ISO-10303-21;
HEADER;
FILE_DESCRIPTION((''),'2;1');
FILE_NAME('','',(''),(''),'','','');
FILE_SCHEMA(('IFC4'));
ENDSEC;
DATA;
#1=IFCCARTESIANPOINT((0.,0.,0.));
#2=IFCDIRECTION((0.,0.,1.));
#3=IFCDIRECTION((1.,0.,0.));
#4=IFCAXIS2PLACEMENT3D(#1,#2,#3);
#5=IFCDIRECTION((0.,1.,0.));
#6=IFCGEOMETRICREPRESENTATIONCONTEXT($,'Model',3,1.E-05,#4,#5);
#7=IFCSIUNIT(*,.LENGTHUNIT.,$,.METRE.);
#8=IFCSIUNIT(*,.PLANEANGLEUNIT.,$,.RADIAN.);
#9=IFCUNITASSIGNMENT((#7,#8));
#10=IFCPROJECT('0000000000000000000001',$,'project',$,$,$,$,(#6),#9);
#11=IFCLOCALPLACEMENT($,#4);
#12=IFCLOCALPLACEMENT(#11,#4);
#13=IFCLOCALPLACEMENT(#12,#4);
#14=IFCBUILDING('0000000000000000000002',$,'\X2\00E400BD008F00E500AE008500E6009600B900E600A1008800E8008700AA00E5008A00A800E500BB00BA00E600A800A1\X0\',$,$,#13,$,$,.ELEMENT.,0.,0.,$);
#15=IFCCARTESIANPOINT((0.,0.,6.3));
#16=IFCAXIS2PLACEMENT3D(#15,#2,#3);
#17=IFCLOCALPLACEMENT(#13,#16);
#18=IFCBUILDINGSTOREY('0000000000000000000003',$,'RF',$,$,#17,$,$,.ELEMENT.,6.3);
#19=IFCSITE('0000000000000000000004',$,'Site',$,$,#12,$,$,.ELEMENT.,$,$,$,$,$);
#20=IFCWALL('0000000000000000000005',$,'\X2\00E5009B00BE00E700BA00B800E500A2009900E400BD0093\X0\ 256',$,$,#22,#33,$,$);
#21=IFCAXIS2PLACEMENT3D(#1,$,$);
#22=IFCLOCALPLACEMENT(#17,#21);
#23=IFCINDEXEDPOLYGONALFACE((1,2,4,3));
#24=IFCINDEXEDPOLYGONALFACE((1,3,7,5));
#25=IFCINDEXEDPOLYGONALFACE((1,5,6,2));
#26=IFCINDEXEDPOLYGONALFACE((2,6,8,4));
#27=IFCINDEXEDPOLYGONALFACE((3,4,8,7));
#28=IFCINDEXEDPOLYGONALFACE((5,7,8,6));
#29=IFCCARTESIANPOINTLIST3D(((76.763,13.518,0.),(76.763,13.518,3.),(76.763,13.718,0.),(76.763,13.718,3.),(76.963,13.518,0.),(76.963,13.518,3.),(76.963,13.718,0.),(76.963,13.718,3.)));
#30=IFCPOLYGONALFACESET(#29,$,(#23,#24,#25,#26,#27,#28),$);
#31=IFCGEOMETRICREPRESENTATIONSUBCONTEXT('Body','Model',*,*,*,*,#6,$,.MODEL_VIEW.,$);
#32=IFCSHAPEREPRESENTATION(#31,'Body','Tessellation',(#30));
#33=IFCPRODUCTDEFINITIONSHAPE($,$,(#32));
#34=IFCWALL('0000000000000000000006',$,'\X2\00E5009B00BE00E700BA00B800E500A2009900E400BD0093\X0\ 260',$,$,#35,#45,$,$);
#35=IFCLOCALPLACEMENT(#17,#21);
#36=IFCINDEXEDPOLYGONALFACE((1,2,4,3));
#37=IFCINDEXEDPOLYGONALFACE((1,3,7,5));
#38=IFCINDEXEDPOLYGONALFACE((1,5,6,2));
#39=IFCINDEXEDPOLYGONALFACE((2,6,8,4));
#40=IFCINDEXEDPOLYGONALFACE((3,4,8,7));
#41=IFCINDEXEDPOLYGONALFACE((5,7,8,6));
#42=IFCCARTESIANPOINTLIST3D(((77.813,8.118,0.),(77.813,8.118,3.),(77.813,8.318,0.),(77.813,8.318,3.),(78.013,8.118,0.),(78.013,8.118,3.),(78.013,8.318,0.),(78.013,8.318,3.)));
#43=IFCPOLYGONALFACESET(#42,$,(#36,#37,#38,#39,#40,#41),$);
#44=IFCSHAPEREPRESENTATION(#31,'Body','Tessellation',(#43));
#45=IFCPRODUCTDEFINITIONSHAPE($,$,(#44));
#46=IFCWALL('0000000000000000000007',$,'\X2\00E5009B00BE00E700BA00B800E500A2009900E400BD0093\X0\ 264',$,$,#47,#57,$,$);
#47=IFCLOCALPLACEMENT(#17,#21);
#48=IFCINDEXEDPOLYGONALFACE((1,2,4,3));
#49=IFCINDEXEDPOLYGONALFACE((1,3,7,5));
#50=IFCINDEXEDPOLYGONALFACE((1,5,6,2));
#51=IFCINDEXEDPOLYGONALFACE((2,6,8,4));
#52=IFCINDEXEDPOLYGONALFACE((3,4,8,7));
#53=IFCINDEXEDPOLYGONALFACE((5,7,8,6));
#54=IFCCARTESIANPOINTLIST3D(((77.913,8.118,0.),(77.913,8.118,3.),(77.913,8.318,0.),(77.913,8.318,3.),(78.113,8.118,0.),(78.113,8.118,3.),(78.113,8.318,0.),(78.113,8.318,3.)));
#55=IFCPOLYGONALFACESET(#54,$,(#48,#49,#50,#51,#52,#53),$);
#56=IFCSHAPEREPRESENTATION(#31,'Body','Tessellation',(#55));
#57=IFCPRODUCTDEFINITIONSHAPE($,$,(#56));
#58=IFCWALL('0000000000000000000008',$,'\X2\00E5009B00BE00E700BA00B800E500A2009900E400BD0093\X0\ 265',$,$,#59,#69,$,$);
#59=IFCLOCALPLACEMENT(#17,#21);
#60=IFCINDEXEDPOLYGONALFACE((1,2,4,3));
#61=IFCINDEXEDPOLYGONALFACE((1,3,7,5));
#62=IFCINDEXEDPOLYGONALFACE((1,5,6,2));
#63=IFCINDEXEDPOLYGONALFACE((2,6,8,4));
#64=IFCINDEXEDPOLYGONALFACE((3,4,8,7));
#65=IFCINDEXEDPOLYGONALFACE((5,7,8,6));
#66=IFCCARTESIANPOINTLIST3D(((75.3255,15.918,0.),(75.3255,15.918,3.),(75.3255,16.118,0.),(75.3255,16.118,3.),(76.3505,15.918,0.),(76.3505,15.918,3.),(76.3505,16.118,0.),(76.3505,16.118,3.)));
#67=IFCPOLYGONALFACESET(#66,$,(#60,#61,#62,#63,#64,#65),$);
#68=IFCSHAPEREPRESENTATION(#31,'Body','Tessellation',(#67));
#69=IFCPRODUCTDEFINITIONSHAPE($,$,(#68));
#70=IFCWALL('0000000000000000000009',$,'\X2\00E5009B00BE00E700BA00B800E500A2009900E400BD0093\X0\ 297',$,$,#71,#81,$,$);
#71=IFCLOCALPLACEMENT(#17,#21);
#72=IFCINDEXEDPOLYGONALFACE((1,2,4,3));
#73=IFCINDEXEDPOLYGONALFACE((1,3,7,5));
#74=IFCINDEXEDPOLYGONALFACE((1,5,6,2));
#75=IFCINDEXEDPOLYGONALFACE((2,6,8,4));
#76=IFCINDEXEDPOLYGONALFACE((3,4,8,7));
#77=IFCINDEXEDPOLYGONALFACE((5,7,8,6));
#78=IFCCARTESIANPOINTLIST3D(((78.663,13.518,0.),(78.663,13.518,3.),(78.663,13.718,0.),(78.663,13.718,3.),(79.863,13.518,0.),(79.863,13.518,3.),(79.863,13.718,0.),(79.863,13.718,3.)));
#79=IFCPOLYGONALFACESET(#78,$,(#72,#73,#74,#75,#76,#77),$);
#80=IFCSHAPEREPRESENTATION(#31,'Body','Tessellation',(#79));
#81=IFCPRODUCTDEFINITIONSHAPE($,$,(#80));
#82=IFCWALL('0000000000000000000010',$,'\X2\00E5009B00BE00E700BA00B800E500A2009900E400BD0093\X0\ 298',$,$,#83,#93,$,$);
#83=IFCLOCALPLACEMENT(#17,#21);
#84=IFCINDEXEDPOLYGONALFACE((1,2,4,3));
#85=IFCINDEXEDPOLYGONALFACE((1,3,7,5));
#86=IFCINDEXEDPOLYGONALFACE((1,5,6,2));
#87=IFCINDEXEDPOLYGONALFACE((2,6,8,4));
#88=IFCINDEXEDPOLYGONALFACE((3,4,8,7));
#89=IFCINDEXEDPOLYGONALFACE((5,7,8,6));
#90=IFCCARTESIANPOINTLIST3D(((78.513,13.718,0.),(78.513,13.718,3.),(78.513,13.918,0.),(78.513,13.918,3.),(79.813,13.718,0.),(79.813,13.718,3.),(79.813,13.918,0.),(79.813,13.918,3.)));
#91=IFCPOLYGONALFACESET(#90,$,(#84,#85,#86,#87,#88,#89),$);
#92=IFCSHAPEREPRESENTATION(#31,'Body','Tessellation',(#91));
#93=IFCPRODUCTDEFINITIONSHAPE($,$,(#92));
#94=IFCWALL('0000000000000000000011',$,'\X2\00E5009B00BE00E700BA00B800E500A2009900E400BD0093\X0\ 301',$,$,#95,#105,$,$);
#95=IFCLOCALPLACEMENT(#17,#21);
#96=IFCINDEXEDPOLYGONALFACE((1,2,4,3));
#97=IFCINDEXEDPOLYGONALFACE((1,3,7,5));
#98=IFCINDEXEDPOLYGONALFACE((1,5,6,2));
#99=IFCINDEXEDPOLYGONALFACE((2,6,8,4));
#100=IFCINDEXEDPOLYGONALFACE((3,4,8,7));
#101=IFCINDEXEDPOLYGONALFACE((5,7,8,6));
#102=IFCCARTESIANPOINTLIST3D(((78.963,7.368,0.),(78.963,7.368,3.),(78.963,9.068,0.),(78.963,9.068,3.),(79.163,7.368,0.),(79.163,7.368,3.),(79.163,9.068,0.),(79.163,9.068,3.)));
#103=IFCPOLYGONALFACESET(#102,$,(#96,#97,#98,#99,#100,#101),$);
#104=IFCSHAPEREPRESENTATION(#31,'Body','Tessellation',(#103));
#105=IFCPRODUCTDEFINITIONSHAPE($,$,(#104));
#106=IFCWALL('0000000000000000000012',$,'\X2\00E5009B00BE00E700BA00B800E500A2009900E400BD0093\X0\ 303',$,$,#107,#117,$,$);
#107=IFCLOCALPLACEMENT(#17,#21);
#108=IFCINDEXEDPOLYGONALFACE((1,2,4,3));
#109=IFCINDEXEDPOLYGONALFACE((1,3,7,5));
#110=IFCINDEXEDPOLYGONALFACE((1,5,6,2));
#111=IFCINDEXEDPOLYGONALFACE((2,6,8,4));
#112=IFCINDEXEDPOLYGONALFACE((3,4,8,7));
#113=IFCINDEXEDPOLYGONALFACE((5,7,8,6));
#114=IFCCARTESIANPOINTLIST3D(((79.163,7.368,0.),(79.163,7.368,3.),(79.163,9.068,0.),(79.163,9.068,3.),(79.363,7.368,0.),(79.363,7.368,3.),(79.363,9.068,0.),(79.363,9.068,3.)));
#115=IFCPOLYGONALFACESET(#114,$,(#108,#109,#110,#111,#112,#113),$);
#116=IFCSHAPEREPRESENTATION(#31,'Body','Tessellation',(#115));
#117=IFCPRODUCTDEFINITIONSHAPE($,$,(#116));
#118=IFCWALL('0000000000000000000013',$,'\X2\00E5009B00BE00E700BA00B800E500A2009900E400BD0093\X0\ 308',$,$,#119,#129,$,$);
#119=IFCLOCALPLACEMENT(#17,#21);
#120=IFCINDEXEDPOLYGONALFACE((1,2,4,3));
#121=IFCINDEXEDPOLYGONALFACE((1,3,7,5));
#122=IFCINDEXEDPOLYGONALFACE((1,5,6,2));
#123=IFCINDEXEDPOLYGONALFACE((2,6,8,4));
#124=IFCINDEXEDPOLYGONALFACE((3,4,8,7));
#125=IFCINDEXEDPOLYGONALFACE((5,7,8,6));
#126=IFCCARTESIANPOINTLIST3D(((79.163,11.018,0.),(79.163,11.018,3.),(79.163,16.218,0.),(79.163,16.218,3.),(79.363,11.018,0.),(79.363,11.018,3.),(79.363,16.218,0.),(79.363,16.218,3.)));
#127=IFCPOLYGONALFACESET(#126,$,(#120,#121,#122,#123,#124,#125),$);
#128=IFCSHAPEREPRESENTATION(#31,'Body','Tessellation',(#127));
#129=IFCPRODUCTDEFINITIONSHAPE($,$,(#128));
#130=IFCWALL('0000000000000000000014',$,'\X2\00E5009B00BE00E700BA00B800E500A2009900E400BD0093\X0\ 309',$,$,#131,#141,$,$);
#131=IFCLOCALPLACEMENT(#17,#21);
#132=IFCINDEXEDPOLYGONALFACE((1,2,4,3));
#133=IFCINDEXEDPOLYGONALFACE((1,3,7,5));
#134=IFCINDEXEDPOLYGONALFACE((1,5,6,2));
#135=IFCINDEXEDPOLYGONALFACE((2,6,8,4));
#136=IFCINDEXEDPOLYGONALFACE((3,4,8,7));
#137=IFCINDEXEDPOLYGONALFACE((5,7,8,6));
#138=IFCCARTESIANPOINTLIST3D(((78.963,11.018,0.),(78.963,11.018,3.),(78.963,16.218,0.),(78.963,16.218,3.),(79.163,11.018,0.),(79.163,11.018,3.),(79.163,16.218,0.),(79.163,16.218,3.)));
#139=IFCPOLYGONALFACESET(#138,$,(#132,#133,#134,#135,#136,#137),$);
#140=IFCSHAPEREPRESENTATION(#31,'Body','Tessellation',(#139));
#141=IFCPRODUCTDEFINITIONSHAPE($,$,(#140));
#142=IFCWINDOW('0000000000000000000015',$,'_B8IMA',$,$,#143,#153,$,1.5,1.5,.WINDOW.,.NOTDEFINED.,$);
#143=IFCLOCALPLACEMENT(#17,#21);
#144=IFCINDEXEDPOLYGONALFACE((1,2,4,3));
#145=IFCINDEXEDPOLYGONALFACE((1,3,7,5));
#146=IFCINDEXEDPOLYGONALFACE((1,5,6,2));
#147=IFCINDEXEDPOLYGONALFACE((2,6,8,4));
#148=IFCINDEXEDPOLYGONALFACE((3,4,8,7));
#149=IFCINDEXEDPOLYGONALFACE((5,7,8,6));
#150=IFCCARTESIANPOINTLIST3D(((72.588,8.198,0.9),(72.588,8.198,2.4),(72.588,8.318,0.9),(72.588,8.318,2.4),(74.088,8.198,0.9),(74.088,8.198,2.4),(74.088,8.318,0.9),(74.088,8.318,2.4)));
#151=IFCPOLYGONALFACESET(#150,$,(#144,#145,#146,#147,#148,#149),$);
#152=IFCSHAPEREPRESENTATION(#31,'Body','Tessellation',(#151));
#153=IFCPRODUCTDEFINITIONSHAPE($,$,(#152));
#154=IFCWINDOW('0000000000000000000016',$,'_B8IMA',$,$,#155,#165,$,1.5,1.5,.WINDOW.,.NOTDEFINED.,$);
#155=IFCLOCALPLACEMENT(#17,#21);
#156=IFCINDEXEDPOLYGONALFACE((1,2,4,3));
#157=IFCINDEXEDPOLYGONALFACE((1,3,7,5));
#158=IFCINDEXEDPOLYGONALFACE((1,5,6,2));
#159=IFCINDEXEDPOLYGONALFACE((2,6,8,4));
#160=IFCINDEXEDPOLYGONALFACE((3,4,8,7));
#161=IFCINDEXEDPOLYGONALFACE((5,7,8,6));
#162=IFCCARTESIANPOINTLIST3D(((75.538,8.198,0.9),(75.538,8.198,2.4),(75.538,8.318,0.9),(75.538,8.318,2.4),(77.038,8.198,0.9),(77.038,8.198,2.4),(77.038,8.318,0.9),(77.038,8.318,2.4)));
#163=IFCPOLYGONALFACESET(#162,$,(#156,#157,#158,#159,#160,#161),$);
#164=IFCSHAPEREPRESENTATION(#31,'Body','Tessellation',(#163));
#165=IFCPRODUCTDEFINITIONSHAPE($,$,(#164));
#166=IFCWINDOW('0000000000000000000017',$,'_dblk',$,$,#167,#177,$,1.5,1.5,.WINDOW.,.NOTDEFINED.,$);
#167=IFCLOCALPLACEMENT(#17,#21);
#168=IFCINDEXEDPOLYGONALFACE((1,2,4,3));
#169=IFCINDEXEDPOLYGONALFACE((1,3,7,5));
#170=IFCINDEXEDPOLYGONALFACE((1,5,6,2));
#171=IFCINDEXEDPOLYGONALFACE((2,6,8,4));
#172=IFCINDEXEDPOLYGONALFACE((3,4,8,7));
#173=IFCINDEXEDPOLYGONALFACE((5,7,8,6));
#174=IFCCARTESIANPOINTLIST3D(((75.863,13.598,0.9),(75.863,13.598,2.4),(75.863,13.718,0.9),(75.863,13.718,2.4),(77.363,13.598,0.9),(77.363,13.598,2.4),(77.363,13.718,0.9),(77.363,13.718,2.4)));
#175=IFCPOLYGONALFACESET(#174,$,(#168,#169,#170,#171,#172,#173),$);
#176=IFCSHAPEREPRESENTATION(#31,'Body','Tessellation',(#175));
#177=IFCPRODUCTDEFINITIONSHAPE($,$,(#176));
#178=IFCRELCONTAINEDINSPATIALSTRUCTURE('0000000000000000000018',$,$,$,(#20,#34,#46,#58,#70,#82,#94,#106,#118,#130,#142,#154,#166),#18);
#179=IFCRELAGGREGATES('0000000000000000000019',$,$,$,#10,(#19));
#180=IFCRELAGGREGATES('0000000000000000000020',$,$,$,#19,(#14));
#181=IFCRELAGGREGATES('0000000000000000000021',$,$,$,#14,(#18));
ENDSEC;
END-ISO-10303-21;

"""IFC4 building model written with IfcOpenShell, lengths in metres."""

from ifc_helpers import new_model, si_unit, direction, frame, frame_2d, origin_with_axes, place, context, subcontext, project, spatial, rectangle, extrude, element, save


model = new_model("IFC4")

# Units and contexts
model_context = context("Model", 3, precision=1e-05, world=origin_with_axes(), true_north=direction((0.0, 1.0, 0.0)))
body_context = subcontext(model_context, "Body", "Model", "MODEL_VIEW")
ifc_project = project(units=[si_unit("LENGTHUNIT", "METRE"), si_unit("PLANEANGLEUNIT", "RADIAN")], contexts=[model_context])

# Site, building, storey
placement = place(None, origin_with_axes())
site_placement = place(placement, origin_with_axes())
site = spatial("IfcSite", under=ifc_project, at=site_placement, Name="Site", CompositionType="ELEMENT")
building_placement = place(site_placement, origin_with_axes())
building = spatial("IfcBuilding", under=site, at=building_placement, Name="ä½\u008få®\u0085æ\u0096¹æ¡\u0088è\u0087ªå\u008a¨å»ºæ¨¡", CompositionType="ELEMENT", ElevationOfRefHeight=0.0, ElevationOfTerrain=0.0)
storey_placement = place(building_placement, frame((0.0, 0.0, 6.3), z_axis=(0.0, 0.0, 1.0), x_axis=(1.0, 0.0, 0.0)))
storey = spatial("IfcBuildingStorey", under=building, at=storey_placement, Name="RF", CompositionType="ELEMENT", Elevation=6.3)

# Walls
for number, where, z_axis, x_axis, name in (
    (1, (76.863, 13.618, 0.0), (0.0, 0.0, 1.0), (0.0, 1.0, 0.0), "å\u009b¾çº¸å¢\u0099ä½\u0093 256"),
    (2, (77.913, 8.218, 0.0), (0.0, 0.0, 1.0), (0.0, 1.0, 0.0), "å\u009b¾çº¸å¢\u0099ä½\u0093 260"),
    (3, (78.013, 8.218, 0.0), (0.0, 0.0, 1.0), (0.0, -1.0, 0.0), "å\u009b¾çº¸å¢\u0099ä½\u0093 264"),
):
    element("IfcWall", number, at=place(storey_placement, frame(where, z_axis=z_axis, x_axis=x_axis)), inside=storey, Name=name, context=body_context, shape_type="SweptSolid", body=[
        extrude(rectangle(XDim=0.2, YDim=0.2, at=frame_2d((0.0, 0.0), x_axis=(1.0, 0.0, 0.0))), frame((0.0, 0.0, 0.0), z_axis=(0.0, 0.0, 1.0)), (0.0, 0.0, 1.0), 3.0),
    ])
wall_1_placement = place(storey_placement, frame((75.838, 16.018, 0.0), z_axis=(0.0, 0.0, 1.0), x_axis=(1.0, 0.0, 0.0)))
element("IfcWall", 4, at=wall_1_placement, inside=storey, Name="å\u009b¾çº¸å¢\u0099ä½\u0093 265", context=body_context, shape_type="SweptSolid", body=[
    extrude(rectangle(XDim=1.025, YDim=0.2, at=frame_2d((0.0, 0.0), x_axis=(1.0, 0.0, 0.0))), frame((0.0, 0.0, 0.0), z_axis=(0.0, 0.0, 1.0)), (0.0, 0.0, 1.0), 3.0),
])
wall_2_placement = place(storey_placement, frame((79.263, 13.618, 0.0), z_axis=(0.0, 0.0, 1.0), x_axis=(1.0, 0.0, 0.0)))
element("IfcWall", 5, at=wall_2_placement, inside=storey, Name="å\u009b¾çº¸å¢\u0099ä½\u0093 297", context=body_context, shape_type="SweptSolid", body=[
    extrude(rectangle(XDim=1.2, YDim=0.2, at=frame_2d((0.0, 0.0), x_axis=(1.0, 0.0, 0.0))), frame((0.0, 0.0, 0.0), z_axis=(0.0, 0.0, 1.0)), (0.0, 0.0, 1.0), 3.0),
])
wall_3_placement = place(storey_placement, frame((79.163, 13.818, 0.0), z_axis=(0.0, 0.0, 1.0), x_axis=(1.0, 0.0, 0.0)))
element("IfcWall", 6, at=wall_3_placement, inside=storey, Name="å\u009b¾çº¸å¢\u0099ä½\u0093 298", context=body_context, shape_type="SweptSolid", body=[
    extrude(rectangle(XDim=1.3, YDim=0.2, at=frame_2d((0.0, 0.0), x_axis=(1.0, 0.0, 0.0))), frame((0.0, 0.0, 0.0), z_axis=(0.0, 0.0, 1.0)), (0.0, 0.0, 1.0), 3.0),
])
for number, where, z_axis, x_axis, name in (
    (7, (79.063, 8.218, 0.0), (0.0, 0.0, 1.0), (0.0, -1.0, 0.0), "å\u009b¾çº¸å¢\u0099ä½\u0093 301"),
    (8, (79.263, 8.218, 0.0), (0.0, 0.0, 1.0), (0.0, -1.0, 0.0), "å\u009b¾çº¸å¢\u0099ä½\u0093 303"),
):
    element("IfcWall", number, at=place(storey_placement, frame(where, z_axis=z_axis, x_axis=x_axis)), inside=storey, Name=name, context=body_context, shape_type="SweptSolid", body=[
        extrude(rectangle(XDim=1.7, YDim=0.2, at=frame_2d((0.0, 0.0), x_axis=(1.0, 0.0, 0.0))), frame((0.0, 0.0, 0.0), z_axis=(0.0, 0.0, 1.0)), (0.0, 0.0, 1.0), 3.0),
    ])
for number, where, z_axis, x_axis, name in (
    (9, (79.263, 13.618, 0.0), (0.0, 0.0, 1.0), (0.0, -1.0, 0.0), "å\u009b¾çº¸å¢\u0099ä½\u0093 308"),
    (10, (79.063, 13.618, 0.0), (0.0, 0.0, 1.0), (0.0, -1.0, 0.0), "å\u009b¾çº¸å¢\u0099ä½\u0093 309"),
):
    element("IfcWall", number, at=place(storey_placement, frame(where, z_axis=z_axis, x_axis=x_axis)), inside=storey, Name=name, context=body_context, shape_type="SweptSolid", body=[
        extrude(rectangle(XDim=5.2, YDim=0.2, at=frame_2d((0.0, 0.0), x_axis=(1.0, 0.0, 0.0))), frame((0.0, 0.0, 0.0), z_axis=(0.0, 0.0, 1.0)), (0.0, 0.0, 1.0), 3.0),
    ])

# Windows
for number, where, z_axis, x_axis, name in (
    (11, (73.338, 8.258, 0.9), (0.0, 0.0, 1.0), (1.0, 0.0, 0.0), "_B8IMA"),
    (12, (76.288, 8.258, 0.9), (0.0, 0.0, 1.0), (1.0, 0.0, 0.0), "_B8IMA"),
    (13, (76.613, 13.658, 0.9), (0.0, 0.0, 1.0), (1.0, 0.0, 0.0), "_dblk"),
):
    element("IfcWindow", number, at=place(storey_placement, frame(where, z_axis=z_axis, x_axis=x_axis)), inside=storey, Name=name, OverallHeight=1.5, OverallWidth=1.5, PartitioningType="NOTDEFINED", PredefinedType="WINDOW", context=body_context, shape_type="SweptSolid", body=[
        extrude(rectangle(XDim=1.5, YDim=0.12, at=frame_2d((0.0, 0.0), x_axis=(1.0, 0.0, 0.0))), frame((0.0, 0.0, 0.0), z_axis=(0.0, 0.0, 1.0)), (0.0, 0.0, 1.0), 1.5),
    ])

save(model, "model.ifc")
